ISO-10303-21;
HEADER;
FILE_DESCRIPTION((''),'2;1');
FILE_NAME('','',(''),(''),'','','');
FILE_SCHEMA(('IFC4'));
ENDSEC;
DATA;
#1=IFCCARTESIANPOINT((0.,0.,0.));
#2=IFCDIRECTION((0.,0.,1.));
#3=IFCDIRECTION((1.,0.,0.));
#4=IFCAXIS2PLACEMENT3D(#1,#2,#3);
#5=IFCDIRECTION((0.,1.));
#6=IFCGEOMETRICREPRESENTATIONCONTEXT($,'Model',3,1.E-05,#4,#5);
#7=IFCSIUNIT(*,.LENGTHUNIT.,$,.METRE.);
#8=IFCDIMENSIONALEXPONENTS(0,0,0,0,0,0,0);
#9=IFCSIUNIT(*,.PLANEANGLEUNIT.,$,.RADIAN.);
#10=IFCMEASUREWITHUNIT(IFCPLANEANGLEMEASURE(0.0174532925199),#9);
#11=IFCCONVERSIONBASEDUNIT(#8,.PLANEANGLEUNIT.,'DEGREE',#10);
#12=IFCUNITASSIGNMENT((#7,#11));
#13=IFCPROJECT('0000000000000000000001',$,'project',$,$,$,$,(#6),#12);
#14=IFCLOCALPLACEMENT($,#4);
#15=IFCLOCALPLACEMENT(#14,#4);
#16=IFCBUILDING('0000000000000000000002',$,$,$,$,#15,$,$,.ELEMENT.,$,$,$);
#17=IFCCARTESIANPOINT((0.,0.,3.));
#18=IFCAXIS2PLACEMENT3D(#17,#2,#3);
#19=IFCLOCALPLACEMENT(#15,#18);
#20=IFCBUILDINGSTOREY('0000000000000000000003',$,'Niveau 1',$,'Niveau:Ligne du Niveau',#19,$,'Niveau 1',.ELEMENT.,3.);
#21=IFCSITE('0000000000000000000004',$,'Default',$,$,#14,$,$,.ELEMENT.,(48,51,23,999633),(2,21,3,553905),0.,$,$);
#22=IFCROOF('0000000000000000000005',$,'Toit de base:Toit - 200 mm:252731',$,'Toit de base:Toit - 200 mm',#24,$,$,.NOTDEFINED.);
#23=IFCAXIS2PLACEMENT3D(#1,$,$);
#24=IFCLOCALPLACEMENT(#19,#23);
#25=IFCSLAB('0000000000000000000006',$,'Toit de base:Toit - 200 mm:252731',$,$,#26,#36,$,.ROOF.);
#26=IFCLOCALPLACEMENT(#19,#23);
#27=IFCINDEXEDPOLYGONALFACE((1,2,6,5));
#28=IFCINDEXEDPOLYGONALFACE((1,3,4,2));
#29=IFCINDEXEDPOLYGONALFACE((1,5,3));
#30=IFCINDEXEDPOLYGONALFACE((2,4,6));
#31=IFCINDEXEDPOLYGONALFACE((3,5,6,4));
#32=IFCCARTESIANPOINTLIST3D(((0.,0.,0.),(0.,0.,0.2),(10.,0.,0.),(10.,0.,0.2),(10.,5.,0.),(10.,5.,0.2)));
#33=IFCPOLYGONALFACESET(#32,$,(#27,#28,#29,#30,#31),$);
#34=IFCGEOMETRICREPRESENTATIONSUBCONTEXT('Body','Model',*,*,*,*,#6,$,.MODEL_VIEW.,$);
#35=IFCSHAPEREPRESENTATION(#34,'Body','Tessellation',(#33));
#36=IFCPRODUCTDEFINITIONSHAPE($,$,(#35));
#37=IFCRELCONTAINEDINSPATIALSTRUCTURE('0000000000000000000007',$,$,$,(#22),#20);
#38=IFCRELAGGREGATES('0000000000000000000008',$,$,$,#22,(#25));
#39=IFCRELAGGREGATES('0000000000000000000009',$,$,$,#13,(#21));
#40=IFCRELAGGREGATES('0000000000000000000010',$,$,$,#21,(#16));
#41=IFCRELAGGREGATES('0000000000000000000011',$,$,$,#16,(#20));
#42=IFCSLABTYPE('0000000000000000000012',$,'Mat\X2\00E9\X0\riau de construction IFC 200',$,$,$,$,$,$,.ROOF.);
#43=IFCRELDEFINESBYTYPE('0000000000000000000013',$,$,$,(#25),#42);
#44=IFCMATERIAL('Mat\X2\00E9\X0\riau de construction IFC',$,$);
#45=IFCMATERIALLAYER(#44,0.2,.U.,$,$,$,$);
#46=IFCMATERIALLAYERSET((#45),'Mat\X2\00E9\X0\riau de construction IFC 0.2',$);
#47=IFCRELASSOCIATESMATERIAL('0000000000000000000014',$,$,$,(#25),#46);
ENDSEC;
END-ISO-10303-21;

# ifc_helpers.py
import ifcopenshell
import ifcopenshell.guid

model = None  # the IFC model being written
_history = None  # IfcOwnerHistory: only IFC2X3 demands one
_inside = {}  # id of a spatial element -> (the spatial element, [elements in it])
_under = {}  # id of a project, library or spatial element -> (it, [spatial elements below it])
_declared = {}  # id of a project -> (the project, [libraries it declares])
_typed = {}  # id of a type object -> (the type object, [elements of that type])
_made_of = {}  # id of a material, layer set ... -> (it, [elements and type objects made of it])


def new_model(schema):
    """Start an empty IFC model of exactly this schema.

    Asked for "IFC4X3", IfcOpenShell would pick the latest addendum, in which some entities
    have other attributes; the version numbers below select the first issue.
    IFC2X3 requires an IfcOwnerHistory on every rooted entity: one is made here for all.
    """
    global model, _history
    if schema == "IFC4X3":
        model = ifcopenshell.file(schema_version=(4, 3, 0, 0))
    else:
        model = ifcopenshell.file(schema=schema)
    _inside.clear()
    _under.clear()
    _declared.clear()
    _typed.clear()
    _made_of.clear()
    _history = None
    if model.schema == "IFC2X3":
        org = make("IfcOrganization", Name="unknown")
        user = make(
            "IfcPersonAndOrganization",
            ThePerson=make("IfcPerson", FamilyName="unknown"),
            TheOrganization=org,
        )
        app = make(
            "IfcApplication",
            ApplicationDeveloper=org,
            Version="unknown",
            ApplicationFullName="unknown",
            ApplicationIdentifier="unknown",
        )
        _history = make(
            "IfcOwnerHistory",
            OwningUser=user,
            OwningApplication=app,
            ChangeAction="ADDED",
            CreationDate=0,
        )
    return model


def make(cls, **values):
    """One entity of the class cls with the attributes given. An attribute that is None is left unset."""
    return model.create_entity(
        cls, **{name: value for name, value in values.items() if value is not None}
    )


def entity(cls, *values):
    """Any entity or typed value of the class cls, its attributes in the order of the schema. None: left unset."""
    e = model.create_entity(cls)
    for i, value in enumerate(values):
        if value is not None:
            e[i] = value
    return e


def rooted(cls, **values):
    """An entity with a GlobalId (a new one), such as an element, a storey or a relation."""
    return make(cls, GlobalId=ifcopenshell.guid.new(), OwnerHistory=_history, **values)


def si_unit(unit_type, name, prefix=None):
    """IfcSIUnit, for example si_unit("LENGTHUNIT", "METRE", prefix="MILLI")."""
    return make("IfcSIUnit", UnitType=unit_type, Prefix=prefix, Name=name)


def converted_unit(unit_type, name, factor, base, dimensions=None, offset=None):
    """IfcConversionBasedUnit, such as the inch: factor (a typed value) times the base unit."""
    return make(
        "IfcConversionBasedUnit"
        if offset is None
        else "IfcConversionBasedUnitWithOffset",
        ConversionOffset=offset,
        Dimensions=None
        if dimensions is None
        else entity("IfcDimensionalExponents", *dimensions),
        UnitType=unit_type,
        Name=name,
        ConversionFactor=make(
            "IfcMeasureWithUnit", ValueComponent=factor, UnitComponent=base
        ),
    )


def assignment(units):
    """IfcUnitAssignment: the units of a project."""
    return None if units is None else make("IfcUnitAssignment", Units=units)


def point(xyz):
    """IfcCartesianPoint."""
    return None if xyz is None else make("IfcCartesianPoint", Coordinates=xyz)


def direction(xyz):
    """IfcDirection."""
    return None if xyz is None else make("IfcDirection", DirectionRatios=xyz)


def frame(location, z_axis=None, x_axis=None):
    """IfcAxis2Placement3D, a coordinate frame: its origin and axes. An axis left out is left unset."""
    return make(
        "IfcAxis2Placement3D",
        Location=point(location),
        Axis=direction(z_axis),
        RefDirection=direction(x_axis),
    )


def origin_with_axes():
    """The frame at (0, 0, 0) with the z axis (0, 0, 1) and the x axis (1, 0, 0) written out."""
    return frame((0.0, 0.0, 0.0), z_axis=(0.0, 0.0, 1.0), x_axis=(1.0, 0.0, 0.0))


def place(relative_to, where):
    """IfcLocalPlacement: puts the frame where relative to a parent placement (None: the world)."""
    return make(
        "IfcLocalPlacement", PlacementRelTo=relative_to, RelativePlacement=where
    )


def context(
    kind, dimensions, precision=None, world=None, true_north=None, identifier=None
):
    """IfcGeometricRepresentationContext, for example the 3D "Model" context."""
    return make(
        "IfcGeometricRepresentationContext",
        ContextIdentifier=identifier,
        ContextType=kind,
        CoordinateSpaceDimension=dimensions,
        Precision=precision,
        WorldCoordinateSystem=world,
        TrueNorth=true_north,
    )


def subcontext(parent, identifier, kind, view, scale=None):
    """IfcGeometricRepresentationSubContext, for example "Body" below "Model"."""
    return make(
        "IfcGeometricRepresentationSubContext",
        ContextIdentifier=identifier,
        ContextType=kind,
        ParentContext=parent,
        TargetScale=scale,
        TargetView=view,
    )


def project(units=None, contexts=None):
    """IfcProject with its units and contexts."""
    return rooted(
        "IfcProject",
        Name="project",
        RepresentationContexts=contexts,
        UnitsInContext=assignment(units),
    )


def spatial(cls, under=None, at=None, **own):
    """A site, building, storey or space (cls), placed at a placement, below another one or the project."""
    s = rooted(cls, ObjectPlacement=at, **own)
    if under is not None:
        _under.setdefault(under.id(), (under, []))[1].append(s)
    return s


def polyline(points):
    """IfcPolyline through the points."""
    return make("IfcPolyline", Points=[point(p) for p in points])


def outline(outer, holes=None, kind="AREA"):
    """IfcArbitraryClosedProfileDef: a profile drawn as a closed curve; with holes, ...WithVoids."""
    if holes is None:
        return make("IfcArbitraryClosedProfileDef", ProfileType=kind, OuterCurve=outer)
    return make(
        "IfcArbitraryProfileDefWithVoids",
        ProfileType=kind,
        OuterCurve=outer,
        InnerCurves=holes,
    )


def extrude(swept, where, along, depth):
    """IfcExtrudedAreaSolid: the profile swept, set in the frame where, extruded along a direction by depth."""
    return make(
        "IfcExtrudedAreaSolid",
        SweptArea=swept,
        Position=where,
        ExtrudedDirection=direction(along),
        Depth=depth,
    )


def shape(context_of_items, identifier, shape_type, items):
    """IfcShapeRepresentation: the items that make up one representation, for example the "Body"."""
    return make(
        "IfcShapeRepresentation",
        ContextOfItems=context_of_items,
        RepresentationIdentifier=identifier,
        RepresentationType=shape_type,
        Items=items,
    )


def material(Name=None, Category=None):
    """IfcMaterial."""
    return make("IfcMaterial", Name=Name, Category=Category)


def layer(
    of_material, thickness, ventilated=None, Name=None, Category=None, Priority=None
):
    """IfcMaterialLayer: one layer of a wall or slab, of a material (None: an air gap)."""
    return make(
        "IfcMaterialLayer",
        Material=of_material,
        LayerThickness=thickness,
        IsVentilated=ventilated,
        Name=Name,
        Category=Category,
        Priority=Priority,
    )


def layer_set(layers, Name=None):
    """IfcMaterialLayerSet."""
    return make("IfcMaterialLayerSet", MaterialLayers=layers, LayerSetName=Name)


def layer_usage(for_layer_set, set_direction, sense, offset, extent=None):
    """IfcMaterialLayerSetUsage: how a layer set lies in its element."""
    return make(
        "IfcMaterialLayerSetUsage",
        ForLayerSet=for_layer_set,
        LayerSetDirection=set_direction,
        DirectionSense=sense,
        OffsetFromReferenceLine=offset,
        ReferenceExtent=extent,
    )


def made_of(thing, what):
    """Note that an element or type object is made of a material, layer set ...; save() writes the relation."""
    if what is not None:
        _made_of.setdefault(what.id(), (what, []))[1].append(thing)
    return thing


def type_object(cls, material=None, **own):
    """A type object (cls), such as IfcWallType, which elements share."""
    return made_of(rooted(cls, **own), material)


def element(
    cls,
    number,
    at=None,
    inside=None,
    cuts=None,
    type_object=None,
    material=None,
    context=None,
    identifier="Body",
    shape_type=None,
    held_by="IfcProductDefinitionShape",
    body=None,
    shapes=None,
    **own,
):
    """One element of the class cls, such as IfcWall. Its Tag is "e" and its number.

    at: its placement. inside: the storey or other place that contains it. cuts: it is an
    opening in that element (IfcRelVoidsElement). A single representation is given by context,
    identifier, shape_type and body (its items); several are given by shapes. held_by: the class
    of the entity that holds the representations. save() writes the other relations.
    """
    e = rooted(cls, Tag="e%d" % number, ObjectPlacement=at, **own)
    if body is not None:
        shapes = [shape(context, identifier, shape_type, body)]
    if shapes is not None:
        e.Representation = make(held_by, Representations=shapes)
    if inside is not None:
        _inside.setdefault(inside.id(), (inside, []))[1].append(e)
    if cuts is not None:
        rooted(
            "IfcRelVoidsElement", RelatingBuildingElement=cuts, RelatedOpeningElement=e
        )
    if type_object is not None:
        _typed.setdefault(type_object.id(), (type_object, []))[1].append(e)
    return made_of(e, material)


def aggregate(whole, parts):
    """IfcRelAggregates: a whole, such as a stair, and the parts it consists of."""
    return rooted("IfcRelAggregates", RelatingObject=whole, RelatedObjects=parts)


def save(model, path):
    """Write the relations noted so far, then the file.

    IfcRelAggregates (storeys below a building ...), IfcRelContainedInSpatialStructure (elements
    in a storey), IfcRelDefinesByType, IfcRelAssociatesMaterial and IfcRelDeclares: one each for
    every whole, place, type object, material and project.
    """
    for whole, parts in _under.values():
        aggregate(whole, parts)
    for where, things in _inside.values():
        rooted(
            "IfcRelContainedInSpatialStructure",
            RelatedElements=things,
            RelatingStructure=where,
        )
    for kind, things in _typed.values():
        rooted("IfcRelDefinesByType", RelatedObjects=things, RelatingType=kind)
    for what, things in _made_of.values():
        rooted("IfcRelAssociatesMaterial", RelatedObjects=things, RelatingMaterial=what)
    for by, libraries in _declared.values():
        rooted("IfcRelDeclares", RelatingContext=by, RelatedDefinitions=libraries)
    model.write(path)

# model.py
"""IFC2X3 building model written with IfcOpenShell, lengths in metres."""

from ifc_helpers import new_model, entity, si_unit, converted_unit, direction, frame, origin_with_axes, place, context, subcontext, project, spatial, polyline, outline, extrude, material, layer, layer_set, layer_usage, type_object, element, aggregate, save


model = new_model("IFC2X3")

# Units and contexts
model_context = context("Model", 3, precision=1e-05, world=origin_with_axes(), true_north=direction((0.0, 1.0)))
body_context = subcontext(model_context, "Body", "Model", "MODEL_VIEW")
ifc_project = project(units=[si_unit("LENGTHUNIT", "METRE"), converted_unit("PLANEANGLEUNIT", "DEGREE", entity("IfcPlaneAngleMeasure", 0.0174532925199), si_unit("PLANEANGLEUNIT", "RADIAN"), dimensions=[0, 0, 0, 0, 0, 0, 0])], contexts=[model_context])

# Site, building, storey
site_placement = place(None, origin_with_axes())
site = spatial("IfcSite", under=ifc_project, at=site_placement, Name="Default", CompositionType="ELEMENT", RefLatitude=(48, 51, 23, 999633), RefLongitude=(2, 21, 3, 553905), RefElevation=0.0)
building_placement = place(site_placement, origin_with_axes())
building = spatial("IfcBuilding", under=site, at=building_placement, CompositionType="ELEMENT")
storey_placement = place(building_placement, frame((0.0, 0.0, 3.0), z_axis=(0.0, 0.0, 1.0), x_axis=(1.0, 0.0, 0.0)))
storey = spatial("IfcBuildingStorey", under=building, at=storey_placement, Name="Niveau 1", ObjectType="Niveau:Ligne du Niveau", LongName="Niveau 1", CompositionType="ELEMENT", Elevation=3.0)

# Roof, slab
roof_placement = place(storey_placement, frame((0.0, 0.0, -3.0), z_axis=(0.0, 0.0, 1.0), x_axis=(1.0, 0.0, 0.0)))
roof = element("IfcRoof", 1, at=roof_placement, inside=storey, Name="Toit de base:Toit - 200 mm:252731", ObjectType="Toit de base:Toit - 200 mm", ShapeType="NOTDEFINED")
ifc_material = material(Name="Matériau de construction IFC")
ifc_layer = layer(ifc_material, 0.2, ventilated="UNKNOWN")
ifc_layer_set = layer_set([ifc_layer], Name="Matériau de construction IFC 0.2")
ifc_layer_usage = layer_usage(ifc_layer_set, "AXIS3", "NEGATIVE", 0.2)
slab_type = type_object("IfcSlabType", Name="Matériau de construction IFC 200", PredefinedType="ROOF")
slab_placement = place(roof_placement, frame((10.0, 5.0, 3.0), z_axis=(0.0, 0.0, 1.0), x_axis=(-0.894427, -0.447214, 0.0)))
slab = element("IfcSlab", 2, at=slab_placement, type_object=slab_type, material=ifc_layer_usage, Name="Toit de base:Toit - 200 mm:252731", PredefinedType="ROOF", context=body_context, shape_type="SweptSolid", body=[
    extrude(outline(polyline([(0.0, 0.0), (11.1803, 0.0), (2.2361, 4.4721), (0.0, 0.0)])), origin_with_axes(), (0.0, 0.0, 1.0), 0.2),
])
aggregate(roof, [slab])

save(model, "model.ifc")
